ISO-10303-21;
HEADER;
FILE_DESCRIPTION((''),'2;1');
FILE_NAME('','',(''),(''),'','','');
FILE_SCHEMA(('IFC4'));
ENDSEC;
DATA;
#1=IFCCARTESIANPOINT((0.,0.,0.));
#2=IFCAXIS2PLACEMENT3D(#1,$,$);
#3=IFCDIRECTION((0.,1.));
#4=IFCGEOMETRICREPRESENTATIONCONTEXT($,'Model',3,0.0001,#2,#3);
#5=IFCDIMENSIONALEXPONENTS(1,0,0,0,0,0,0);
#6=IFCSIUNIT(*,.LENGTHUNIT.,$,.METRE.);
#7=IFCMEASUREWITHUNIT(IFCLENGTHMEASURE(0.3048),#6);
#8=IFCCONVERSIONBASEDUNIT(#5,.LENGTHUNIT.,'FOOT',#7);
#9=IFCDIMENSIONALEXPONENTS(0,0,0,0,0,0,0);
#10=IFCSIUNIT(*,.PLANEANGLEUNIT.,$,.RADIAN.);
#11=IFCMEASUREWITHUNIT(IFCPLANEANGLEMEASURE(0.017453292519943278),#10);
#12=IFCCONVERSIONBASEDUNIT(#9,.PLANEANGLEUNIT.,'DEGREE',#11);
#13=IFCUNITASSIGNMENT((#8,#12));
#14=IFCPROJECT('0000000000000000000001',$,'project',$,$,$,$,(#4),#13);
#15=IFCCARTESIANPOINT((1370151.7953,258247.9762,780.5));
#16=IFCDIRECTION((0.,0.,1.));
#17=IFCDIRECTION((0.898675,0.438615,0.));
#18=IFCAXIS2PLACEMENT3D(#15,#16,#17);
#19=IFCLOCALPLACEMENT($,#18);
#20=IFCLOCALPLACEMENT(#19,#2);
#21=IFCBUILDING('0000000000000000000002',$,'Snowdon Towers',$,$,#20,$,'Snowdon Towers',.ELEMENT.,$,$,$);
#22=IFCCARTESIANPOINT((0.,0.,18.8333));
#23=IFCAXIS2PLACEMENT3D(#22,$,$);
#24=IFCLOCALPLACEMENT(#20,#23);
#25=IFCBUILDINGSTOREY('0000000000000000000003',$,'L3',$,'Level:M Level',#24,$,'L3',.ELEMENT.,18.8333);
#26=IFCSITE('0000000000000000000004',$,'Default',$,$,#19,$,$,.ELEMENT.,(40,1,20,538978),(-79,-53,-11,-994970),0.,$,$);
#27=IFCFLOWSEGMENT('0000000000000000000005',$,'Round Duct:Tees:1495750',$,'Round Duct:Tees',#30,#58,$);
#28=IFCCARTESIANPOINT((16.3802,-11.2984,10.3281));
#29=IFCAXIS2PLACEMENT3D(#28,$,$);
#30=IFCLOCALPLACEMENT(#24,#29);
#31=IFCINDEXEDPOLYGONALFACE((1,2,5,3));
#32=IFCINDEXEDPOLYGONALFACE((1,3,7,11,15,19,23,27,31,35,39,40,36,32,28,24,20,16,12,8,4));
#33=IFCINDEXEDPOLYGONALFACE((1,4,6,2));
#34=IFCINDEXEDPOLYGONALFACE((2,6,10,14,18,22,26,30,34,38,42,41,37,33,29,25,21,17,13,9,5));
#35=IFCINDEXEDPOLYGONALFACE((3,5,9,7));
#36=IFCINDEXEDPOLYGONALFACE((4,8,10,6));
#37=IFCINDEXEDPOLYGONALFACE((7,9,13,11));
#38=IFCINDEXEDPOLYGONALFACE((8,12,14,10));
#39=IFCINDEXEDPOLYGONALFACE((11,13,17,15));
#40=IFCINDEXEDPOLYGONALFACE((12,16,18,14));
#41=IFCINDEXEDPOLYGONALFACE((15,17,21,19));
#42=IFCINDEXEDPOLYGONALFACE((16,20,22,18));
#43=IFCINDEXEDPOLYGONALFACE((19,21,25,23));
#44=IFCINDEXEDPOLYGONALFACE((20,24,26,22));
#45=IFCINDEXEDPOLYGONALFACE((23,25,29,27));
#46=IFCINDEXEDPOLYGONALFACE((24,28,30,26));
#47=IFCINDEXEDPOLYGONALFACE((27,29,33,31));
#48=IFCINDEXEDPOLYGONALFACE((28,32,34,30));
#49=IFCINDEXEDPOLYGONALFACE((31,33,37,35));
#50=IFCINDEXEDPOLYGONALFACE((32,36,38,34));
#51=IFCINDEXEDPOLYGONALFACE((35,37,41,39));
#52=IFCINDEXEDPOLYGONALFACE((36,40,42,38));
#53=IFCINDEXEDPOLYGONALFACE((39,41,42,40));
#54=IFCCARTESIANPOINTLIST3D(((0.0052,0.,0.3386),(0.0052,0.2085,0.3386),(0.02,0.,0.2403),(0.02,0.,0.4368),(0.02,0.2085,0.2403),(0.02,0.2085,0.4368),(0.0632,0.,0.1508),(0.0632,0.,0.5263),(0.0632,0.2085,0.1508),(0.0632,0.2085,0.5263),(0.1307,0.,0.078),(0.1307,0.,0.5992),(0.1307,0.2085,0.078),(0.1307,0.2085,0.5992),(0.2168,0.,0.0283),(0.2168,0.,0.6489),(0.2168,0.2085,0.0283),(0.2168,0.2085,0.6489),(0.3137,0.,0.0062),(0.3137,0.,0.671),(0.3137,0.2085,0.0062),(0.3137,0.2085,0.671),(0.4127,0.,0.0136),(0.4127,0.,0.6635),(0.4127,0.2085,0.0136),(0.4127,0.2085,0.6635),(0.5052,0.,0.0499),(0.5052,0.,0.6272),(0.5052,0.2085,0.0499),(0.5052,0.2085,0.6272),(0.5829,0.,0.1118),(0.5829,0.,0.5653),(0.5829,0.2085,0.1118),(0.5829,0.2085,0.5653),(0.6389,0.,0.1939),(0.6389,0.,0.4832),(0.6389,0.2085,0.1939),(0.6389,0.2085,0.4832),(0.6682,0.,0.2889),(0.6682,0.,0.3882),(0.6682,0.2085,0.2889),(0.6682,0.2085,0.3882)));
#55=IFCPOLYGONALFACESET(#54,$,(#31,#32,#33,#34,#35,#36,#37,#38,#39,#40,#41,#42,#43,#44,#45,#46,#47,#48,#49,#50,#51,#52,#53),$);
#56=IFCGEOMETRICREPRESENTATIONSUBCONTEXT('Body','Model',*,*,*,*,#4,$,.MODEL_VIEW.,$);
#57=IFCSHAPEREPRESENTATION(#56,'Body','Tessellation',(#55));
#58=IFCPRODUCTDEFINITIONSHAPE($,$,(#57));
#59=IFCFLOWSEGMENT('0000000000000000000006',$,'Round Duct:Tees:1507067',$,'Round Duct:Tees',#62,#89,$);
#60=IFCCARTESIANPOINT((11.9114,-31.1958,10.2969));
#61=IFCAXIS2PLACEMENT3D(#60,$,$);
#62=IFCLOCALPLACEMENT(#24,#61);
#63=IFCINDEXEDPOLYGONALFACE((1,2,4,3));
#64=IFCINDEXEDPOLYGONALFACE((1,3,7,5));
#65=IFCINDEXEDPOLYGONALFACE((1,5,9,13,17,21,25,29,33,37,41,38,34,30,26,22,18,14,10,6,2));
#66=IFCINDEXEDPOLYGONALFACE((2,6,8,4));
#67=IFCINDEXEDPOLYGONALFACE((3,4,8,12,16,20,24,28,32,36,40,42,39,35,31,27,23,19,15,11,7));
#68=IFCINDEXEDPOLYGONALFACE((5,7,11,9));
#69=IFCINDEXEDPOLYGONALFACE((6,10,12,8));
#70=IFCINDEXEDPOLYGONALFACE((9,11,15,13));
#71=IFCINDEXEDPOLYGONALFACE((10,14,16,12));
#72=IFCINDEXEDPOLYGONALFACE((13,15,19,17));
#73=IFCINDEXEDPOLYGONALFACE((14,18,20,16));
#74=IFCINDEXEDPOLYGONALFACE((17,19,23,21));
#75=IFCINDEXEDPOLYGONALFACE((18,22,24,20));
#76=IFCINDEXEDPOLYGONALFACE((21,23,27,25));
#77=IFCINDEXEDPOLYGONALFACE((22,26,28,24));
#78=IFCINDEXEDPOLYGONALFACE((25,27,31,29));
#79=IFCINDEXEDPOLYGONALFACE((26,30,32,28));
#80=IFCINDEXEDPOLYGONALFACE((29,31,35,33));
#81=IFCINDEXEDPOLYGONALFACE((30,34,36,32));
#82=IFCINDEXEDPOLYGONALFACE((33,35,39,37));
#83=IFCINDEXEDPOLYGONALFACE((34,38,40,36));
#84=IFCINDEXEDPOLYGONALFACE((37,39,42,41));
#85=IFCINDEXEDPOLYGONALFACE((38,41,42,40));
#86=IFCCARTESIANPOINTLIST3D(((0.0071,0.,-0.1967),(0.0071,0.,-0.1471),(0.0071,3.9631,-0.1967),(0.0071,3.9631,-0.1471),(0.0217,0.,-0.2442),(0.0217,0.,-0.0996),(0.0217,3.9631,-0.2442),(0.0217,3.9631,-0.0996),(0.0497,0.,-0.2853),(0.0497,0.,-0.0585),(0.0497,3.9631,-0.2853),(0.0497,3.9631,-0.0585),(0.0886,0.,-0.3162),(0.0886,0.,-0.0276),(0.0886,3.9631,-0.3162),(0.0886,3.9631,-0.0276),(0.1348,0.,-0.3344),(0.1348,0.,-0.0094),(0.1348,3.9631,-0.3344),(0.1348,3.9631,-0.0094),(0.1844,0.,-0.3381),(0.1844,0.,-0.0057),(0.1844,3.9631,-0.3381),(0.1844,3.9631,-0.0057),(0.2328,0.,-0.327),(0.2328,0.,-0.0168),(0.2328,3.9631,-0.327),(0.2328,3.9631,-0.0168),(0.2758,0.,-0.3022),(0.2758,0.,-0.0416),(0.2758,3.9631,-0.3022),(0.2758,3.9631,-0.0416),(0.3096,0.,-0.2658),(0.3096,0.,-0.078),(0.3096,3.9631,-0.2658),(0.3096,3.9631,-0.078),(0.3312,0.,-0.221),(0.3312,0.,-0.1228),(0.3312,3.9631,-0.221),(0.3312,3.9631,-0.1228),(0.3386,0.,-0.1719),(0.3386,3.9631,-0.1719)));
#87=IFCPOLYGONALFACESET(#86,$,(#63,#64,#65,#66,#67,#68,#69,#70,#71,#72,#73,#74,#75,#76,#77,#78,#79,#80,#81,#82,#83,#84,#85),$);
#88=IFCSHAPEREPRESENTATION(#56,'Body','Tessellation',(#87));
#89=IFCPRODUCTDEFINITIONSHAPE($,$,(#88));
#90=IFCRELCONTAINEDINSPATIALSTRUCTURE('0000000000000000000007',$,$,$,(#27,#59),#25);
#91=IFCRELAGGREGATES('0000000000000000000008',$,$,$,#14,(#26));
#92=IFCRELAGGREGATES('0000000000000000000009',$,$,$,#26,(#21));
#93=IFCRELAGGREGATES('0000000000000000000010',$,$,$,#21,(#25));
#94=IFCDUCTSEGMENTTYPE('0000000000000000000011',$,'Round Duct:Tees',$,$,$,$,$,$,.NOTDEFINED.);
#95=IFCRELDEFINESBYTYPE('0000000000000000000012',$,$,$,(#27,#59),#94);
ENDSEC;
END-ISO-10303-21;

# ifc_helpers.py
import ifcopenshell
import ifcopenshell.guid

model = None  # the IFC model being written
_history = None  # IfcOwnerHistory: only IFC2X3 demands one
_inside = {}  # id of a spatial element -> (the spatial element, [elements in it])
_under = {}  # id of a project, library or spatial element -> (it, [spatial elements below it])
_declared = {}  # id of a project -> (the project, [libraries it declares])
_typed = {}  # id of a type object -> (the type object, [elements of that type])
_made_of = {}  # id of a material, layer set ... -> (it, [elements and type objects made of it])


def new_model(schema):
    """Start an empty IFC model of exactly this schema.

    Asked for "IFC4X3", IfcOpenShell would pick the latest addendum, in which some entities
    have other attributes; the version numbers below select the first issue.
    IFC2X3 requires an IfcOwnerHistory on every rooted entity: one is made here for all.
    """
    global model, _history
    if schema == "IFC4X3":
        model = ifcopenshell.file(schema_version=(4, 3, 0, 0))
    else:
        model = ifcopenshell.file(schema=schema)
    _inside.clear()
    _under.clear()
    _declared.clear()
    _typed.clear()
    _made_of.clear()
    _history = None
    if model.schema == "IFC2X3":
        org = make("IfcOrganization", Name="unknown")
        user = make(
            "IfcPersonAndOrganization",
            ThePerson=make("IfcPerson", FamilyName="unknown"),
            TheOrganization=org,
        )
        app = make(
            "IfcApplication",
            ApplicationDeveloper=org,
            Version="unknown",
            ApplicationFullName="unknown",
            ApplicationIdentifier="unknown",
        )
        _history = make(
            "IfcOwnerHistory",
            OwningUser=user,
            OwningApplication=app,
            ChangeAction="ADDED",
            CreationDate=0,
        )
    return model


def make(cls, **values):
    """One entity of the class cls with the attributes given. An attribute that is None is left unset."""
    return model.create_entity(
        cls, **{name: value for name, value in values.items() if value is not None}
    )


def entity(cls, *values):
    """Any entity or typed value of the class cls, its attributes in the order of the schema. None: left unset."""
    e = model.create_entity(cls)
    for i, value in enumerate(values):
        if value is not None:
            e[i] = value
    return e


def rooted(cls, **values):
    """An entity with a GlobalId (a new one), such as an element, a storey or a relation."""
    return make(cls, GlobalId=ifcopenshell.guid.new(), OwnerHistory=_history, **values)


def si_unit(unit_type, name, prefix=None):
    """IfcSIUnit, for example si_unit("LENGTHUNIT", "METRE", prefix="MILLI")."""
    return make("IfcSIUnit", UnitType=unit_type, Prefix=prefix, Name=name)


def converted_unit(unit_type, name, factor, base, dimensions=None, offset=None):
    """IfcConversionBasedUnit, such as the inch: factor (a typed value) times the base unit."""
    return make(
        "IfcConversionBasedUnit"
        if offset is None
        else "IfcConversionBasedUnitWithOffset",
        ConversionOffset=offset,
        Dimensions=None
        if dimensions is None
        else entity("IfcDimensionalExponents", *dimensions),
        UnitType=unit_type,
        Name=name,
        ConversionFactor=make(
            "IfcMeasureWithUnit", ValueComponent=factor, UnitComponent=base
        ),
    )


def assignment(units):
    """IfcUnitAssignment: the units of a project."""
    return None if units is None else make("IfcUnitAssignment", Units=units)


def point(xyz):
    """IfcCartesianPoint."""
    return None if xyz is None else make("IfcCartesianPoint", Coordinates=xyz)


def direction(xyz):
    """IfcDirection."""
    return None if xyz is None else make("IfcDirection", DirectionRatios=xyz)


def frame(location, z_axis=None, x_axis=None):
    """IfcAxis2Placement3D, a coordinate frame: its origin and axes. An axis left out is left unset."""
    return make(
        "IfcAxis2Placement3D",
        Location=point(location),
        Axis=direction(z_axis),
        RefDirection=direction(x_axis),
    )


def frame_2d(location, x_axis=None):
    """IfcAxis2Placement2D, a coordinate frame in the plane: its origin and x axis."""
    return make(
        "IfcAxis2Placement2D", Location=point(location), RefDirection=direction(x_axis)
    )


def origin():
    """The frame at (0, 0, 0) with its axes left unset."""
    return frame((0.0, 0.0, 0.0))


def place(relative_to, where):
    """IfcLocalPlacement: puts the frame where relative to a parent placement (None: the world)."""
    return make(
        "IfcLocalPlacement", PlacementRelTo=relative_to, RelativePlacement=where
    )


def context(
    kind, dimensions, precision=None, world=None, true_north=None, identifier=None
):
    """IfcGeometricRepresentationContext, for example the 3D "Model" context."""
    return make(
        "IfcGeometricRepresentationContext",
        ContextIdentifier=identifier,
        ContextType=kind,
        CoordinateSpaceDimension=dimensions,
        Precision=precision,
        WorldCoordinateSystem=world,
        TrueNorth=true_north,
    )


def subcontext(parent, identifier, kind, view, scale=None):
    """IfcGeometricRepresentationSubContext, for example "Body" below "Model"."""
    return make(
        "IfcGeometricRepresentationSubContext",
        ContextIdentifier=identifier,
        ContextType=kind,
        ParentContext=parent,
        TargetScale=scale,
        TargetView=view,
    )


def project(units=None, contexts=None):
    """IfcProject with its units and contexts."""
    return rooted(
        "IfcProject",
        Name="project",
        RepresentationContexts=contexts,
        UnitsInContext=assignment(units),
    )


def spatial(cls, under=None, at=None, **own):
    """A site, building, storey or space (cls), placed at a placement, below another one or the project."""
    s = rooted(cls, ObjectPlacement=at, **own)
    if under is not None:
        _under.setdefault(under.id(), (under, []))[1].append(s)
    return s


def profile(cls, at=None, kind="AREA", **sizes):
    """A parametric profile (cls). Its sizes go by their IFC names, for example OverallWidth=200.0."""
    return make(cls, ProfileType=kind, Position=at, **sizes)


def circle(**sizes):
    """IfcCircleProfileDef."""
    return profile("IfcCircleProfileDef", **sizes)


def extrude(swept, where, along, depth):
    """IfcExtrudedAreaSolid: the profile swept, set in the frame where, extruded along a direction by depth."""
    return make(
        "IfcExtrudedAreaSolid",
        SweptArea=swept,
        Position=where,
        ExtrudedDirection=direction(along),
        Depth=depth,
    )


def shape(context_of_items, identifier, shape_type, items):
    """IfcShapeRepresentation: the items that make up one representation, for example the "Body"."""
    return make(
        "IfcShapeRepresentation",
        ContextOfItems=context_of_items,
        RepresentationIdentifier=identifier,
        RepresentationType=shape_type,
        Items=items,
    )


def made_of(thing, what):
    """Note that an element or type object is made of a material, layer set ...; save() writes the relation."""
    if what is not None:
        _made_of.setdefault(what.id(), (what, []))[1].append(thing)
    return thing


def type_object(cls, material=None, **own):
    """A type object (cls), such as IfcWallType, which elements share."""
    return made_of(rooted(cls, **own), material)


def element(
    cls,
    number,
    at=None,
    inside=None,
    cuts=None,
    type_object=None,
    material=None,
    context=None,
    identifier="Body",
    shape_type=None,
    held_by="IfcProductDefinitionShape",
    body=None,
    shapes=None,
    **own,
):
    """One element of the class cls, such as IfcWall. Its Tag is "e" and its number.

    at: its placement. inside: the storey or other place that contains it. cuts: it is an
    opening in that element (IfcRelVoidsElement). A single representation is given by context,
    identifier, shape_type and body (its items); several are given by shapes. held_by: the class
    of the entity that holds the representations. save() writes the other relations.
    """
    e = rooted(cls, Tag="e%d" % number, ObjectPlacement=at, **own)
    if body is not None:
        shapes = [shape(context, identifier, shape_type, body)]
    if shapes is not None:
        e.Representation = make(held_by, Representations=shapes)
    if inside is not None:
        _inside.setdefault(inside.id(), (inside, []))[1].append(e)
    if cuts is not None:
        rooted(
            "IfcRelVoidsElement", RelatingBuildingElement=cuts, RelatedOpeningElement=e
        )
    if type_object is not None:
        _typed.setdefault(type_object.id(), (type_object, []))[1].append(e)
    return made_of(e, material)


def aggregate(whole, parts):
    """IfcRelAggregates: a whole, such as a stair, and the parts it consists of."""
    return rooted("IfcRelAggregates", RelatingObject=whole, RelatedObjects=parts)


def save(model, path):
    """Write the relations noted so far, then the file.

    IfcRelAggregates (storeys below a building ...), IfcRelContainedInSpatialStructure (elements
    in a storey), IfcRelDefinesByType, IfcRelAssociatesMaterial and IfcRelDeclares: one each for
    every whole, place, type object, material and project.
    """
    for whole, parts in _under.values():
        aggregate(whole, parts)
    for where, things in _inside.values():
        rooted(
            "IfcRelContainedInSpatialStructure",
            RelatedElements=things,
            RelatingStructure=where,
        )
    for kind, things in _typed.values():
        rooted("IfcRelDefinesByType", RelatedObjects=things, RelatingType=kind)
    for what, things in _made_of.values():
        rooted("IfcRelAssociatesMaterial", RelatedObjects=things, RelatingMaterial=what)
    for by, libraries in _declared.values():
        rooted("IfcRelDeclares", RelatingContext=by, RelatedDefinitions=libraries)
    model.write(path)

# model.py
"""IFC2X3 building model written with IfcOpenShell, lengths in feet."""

from ifc_helpers import new_model, entity, si_unit, converted_unit, direction, frame, frame_2d, origin, place, context, subcontext, project, spatial, circle, extrude, type_object, element, save


model = new_model("IFC2X3")

# Units and contexts
model_context = context("Model", 3, precision=0.0001, world=origin(), true_north=direction((0.0, 1.0)))
body_context = subcontext(model_context, "Body", "Model", "MODEL_VIEW")
ifc_project = project(units=[converted_unit("LENGTHUNIT", "FOOT", entity("IfcLengthMeasure", 0.3048), si_unit("LENGTHUNIT", "METRE"), dimensions=[1, 0, 0, 0, 0, 0, 0]), converted_unit("PLANEANGLEUNIT", "DEGREE", entity("IfcPlaneAngleMeasure", 0.017453292519943278), si_unit("PLANEANGLEUNIT", "RADIAN"), dimensions=[0, 0, 0, 0, 0, 0, 0])], contexts=[model_context])

# Site, building, storey
site_placement = place(None, frame((1370151.7953, 258247.9762, 780.5), z_axis=(0.0, 0.0, 1.0), x_axis=(0.898675, 0.438615, 0.0)))
site = spatial("IfcSite", under=ifc_project, at=site_placement, Name="Default", CompositionType="ELEMENT", RefLatitude=(40, 1, 20, 538978), RefLongitude=(-79, -53, -11, -994970), RefElevation=0.0)
building_placement = place(site_placement, origin())
building = spatial("IfcBuilding", under=site, at=building_placement, Name="Snowdon Towers", LongName="Snowdon Towers", CompositionType="ELEMENT")
storey_placement = place(building_placement, frame((0.0, 0.0, 18.8333)))
storey = spatial("IfcBuildingStorey", under=building, at=storey_placement, Name="L3", ObjectType="Level:M Level", LongName="L3", CompositionType="ELEMENT", Elevation=18.8333)

# Flow segments
duct_segment_type = type_object("IfcDuctSegmentType", Name="Round Duct:Tees", PredefinedType="NOTDEFINED")
flow_segment_1_placement = place(storey_placement, frame((16.3802, -11.2984, 10.3281)))
element("IfcFlowSegment", 1, at=flow_segment_1_placement, inside=storey, type_object=duct_segment_type, Name="Round Duct:Tees:1495750", ObjectType="Round Duct:Tees", context=body_context, shape_type="SweptSolid", body=[
    extrude(circle(Radius=0.3333, at=frame_2d((0.0, 0.0), x_axis=(1.0, 0.0))), frame((0.3386, 0.0, 0.3386), z_axis=(0.0, 1.0, 0.0), x_axis=(-1.0, 0.0, 0.0)), (0.0, 0.0, 1.0), 0.2085),
])
flow_segment_2_placement = place(storey_placement, frame((11.9114, -31.1958, 10.2969)))
element("IfcFlowSegment", 2, at=flow_segment_2_placement, inside=storey, type_object=duct_segment_type, Name="Round Duct:Tees:1507067", ObjectType="Round Duct:Tees", context=body_context, shape_type="SweptSolid", body=[
    extrude(circle(Radius=0.1667, at=frame_2d((0.0, 0.0), x_axis=(1.0, 0.0))), frame((0.1719, 0.0, -0.1719), z_axis=(0.0, 1.0, 0.0), x_axis=(1.0, 0.0, 0.0)), (0.0, 0.0, 1.0), 3.9631),
])

save(model, "model.ifc")
